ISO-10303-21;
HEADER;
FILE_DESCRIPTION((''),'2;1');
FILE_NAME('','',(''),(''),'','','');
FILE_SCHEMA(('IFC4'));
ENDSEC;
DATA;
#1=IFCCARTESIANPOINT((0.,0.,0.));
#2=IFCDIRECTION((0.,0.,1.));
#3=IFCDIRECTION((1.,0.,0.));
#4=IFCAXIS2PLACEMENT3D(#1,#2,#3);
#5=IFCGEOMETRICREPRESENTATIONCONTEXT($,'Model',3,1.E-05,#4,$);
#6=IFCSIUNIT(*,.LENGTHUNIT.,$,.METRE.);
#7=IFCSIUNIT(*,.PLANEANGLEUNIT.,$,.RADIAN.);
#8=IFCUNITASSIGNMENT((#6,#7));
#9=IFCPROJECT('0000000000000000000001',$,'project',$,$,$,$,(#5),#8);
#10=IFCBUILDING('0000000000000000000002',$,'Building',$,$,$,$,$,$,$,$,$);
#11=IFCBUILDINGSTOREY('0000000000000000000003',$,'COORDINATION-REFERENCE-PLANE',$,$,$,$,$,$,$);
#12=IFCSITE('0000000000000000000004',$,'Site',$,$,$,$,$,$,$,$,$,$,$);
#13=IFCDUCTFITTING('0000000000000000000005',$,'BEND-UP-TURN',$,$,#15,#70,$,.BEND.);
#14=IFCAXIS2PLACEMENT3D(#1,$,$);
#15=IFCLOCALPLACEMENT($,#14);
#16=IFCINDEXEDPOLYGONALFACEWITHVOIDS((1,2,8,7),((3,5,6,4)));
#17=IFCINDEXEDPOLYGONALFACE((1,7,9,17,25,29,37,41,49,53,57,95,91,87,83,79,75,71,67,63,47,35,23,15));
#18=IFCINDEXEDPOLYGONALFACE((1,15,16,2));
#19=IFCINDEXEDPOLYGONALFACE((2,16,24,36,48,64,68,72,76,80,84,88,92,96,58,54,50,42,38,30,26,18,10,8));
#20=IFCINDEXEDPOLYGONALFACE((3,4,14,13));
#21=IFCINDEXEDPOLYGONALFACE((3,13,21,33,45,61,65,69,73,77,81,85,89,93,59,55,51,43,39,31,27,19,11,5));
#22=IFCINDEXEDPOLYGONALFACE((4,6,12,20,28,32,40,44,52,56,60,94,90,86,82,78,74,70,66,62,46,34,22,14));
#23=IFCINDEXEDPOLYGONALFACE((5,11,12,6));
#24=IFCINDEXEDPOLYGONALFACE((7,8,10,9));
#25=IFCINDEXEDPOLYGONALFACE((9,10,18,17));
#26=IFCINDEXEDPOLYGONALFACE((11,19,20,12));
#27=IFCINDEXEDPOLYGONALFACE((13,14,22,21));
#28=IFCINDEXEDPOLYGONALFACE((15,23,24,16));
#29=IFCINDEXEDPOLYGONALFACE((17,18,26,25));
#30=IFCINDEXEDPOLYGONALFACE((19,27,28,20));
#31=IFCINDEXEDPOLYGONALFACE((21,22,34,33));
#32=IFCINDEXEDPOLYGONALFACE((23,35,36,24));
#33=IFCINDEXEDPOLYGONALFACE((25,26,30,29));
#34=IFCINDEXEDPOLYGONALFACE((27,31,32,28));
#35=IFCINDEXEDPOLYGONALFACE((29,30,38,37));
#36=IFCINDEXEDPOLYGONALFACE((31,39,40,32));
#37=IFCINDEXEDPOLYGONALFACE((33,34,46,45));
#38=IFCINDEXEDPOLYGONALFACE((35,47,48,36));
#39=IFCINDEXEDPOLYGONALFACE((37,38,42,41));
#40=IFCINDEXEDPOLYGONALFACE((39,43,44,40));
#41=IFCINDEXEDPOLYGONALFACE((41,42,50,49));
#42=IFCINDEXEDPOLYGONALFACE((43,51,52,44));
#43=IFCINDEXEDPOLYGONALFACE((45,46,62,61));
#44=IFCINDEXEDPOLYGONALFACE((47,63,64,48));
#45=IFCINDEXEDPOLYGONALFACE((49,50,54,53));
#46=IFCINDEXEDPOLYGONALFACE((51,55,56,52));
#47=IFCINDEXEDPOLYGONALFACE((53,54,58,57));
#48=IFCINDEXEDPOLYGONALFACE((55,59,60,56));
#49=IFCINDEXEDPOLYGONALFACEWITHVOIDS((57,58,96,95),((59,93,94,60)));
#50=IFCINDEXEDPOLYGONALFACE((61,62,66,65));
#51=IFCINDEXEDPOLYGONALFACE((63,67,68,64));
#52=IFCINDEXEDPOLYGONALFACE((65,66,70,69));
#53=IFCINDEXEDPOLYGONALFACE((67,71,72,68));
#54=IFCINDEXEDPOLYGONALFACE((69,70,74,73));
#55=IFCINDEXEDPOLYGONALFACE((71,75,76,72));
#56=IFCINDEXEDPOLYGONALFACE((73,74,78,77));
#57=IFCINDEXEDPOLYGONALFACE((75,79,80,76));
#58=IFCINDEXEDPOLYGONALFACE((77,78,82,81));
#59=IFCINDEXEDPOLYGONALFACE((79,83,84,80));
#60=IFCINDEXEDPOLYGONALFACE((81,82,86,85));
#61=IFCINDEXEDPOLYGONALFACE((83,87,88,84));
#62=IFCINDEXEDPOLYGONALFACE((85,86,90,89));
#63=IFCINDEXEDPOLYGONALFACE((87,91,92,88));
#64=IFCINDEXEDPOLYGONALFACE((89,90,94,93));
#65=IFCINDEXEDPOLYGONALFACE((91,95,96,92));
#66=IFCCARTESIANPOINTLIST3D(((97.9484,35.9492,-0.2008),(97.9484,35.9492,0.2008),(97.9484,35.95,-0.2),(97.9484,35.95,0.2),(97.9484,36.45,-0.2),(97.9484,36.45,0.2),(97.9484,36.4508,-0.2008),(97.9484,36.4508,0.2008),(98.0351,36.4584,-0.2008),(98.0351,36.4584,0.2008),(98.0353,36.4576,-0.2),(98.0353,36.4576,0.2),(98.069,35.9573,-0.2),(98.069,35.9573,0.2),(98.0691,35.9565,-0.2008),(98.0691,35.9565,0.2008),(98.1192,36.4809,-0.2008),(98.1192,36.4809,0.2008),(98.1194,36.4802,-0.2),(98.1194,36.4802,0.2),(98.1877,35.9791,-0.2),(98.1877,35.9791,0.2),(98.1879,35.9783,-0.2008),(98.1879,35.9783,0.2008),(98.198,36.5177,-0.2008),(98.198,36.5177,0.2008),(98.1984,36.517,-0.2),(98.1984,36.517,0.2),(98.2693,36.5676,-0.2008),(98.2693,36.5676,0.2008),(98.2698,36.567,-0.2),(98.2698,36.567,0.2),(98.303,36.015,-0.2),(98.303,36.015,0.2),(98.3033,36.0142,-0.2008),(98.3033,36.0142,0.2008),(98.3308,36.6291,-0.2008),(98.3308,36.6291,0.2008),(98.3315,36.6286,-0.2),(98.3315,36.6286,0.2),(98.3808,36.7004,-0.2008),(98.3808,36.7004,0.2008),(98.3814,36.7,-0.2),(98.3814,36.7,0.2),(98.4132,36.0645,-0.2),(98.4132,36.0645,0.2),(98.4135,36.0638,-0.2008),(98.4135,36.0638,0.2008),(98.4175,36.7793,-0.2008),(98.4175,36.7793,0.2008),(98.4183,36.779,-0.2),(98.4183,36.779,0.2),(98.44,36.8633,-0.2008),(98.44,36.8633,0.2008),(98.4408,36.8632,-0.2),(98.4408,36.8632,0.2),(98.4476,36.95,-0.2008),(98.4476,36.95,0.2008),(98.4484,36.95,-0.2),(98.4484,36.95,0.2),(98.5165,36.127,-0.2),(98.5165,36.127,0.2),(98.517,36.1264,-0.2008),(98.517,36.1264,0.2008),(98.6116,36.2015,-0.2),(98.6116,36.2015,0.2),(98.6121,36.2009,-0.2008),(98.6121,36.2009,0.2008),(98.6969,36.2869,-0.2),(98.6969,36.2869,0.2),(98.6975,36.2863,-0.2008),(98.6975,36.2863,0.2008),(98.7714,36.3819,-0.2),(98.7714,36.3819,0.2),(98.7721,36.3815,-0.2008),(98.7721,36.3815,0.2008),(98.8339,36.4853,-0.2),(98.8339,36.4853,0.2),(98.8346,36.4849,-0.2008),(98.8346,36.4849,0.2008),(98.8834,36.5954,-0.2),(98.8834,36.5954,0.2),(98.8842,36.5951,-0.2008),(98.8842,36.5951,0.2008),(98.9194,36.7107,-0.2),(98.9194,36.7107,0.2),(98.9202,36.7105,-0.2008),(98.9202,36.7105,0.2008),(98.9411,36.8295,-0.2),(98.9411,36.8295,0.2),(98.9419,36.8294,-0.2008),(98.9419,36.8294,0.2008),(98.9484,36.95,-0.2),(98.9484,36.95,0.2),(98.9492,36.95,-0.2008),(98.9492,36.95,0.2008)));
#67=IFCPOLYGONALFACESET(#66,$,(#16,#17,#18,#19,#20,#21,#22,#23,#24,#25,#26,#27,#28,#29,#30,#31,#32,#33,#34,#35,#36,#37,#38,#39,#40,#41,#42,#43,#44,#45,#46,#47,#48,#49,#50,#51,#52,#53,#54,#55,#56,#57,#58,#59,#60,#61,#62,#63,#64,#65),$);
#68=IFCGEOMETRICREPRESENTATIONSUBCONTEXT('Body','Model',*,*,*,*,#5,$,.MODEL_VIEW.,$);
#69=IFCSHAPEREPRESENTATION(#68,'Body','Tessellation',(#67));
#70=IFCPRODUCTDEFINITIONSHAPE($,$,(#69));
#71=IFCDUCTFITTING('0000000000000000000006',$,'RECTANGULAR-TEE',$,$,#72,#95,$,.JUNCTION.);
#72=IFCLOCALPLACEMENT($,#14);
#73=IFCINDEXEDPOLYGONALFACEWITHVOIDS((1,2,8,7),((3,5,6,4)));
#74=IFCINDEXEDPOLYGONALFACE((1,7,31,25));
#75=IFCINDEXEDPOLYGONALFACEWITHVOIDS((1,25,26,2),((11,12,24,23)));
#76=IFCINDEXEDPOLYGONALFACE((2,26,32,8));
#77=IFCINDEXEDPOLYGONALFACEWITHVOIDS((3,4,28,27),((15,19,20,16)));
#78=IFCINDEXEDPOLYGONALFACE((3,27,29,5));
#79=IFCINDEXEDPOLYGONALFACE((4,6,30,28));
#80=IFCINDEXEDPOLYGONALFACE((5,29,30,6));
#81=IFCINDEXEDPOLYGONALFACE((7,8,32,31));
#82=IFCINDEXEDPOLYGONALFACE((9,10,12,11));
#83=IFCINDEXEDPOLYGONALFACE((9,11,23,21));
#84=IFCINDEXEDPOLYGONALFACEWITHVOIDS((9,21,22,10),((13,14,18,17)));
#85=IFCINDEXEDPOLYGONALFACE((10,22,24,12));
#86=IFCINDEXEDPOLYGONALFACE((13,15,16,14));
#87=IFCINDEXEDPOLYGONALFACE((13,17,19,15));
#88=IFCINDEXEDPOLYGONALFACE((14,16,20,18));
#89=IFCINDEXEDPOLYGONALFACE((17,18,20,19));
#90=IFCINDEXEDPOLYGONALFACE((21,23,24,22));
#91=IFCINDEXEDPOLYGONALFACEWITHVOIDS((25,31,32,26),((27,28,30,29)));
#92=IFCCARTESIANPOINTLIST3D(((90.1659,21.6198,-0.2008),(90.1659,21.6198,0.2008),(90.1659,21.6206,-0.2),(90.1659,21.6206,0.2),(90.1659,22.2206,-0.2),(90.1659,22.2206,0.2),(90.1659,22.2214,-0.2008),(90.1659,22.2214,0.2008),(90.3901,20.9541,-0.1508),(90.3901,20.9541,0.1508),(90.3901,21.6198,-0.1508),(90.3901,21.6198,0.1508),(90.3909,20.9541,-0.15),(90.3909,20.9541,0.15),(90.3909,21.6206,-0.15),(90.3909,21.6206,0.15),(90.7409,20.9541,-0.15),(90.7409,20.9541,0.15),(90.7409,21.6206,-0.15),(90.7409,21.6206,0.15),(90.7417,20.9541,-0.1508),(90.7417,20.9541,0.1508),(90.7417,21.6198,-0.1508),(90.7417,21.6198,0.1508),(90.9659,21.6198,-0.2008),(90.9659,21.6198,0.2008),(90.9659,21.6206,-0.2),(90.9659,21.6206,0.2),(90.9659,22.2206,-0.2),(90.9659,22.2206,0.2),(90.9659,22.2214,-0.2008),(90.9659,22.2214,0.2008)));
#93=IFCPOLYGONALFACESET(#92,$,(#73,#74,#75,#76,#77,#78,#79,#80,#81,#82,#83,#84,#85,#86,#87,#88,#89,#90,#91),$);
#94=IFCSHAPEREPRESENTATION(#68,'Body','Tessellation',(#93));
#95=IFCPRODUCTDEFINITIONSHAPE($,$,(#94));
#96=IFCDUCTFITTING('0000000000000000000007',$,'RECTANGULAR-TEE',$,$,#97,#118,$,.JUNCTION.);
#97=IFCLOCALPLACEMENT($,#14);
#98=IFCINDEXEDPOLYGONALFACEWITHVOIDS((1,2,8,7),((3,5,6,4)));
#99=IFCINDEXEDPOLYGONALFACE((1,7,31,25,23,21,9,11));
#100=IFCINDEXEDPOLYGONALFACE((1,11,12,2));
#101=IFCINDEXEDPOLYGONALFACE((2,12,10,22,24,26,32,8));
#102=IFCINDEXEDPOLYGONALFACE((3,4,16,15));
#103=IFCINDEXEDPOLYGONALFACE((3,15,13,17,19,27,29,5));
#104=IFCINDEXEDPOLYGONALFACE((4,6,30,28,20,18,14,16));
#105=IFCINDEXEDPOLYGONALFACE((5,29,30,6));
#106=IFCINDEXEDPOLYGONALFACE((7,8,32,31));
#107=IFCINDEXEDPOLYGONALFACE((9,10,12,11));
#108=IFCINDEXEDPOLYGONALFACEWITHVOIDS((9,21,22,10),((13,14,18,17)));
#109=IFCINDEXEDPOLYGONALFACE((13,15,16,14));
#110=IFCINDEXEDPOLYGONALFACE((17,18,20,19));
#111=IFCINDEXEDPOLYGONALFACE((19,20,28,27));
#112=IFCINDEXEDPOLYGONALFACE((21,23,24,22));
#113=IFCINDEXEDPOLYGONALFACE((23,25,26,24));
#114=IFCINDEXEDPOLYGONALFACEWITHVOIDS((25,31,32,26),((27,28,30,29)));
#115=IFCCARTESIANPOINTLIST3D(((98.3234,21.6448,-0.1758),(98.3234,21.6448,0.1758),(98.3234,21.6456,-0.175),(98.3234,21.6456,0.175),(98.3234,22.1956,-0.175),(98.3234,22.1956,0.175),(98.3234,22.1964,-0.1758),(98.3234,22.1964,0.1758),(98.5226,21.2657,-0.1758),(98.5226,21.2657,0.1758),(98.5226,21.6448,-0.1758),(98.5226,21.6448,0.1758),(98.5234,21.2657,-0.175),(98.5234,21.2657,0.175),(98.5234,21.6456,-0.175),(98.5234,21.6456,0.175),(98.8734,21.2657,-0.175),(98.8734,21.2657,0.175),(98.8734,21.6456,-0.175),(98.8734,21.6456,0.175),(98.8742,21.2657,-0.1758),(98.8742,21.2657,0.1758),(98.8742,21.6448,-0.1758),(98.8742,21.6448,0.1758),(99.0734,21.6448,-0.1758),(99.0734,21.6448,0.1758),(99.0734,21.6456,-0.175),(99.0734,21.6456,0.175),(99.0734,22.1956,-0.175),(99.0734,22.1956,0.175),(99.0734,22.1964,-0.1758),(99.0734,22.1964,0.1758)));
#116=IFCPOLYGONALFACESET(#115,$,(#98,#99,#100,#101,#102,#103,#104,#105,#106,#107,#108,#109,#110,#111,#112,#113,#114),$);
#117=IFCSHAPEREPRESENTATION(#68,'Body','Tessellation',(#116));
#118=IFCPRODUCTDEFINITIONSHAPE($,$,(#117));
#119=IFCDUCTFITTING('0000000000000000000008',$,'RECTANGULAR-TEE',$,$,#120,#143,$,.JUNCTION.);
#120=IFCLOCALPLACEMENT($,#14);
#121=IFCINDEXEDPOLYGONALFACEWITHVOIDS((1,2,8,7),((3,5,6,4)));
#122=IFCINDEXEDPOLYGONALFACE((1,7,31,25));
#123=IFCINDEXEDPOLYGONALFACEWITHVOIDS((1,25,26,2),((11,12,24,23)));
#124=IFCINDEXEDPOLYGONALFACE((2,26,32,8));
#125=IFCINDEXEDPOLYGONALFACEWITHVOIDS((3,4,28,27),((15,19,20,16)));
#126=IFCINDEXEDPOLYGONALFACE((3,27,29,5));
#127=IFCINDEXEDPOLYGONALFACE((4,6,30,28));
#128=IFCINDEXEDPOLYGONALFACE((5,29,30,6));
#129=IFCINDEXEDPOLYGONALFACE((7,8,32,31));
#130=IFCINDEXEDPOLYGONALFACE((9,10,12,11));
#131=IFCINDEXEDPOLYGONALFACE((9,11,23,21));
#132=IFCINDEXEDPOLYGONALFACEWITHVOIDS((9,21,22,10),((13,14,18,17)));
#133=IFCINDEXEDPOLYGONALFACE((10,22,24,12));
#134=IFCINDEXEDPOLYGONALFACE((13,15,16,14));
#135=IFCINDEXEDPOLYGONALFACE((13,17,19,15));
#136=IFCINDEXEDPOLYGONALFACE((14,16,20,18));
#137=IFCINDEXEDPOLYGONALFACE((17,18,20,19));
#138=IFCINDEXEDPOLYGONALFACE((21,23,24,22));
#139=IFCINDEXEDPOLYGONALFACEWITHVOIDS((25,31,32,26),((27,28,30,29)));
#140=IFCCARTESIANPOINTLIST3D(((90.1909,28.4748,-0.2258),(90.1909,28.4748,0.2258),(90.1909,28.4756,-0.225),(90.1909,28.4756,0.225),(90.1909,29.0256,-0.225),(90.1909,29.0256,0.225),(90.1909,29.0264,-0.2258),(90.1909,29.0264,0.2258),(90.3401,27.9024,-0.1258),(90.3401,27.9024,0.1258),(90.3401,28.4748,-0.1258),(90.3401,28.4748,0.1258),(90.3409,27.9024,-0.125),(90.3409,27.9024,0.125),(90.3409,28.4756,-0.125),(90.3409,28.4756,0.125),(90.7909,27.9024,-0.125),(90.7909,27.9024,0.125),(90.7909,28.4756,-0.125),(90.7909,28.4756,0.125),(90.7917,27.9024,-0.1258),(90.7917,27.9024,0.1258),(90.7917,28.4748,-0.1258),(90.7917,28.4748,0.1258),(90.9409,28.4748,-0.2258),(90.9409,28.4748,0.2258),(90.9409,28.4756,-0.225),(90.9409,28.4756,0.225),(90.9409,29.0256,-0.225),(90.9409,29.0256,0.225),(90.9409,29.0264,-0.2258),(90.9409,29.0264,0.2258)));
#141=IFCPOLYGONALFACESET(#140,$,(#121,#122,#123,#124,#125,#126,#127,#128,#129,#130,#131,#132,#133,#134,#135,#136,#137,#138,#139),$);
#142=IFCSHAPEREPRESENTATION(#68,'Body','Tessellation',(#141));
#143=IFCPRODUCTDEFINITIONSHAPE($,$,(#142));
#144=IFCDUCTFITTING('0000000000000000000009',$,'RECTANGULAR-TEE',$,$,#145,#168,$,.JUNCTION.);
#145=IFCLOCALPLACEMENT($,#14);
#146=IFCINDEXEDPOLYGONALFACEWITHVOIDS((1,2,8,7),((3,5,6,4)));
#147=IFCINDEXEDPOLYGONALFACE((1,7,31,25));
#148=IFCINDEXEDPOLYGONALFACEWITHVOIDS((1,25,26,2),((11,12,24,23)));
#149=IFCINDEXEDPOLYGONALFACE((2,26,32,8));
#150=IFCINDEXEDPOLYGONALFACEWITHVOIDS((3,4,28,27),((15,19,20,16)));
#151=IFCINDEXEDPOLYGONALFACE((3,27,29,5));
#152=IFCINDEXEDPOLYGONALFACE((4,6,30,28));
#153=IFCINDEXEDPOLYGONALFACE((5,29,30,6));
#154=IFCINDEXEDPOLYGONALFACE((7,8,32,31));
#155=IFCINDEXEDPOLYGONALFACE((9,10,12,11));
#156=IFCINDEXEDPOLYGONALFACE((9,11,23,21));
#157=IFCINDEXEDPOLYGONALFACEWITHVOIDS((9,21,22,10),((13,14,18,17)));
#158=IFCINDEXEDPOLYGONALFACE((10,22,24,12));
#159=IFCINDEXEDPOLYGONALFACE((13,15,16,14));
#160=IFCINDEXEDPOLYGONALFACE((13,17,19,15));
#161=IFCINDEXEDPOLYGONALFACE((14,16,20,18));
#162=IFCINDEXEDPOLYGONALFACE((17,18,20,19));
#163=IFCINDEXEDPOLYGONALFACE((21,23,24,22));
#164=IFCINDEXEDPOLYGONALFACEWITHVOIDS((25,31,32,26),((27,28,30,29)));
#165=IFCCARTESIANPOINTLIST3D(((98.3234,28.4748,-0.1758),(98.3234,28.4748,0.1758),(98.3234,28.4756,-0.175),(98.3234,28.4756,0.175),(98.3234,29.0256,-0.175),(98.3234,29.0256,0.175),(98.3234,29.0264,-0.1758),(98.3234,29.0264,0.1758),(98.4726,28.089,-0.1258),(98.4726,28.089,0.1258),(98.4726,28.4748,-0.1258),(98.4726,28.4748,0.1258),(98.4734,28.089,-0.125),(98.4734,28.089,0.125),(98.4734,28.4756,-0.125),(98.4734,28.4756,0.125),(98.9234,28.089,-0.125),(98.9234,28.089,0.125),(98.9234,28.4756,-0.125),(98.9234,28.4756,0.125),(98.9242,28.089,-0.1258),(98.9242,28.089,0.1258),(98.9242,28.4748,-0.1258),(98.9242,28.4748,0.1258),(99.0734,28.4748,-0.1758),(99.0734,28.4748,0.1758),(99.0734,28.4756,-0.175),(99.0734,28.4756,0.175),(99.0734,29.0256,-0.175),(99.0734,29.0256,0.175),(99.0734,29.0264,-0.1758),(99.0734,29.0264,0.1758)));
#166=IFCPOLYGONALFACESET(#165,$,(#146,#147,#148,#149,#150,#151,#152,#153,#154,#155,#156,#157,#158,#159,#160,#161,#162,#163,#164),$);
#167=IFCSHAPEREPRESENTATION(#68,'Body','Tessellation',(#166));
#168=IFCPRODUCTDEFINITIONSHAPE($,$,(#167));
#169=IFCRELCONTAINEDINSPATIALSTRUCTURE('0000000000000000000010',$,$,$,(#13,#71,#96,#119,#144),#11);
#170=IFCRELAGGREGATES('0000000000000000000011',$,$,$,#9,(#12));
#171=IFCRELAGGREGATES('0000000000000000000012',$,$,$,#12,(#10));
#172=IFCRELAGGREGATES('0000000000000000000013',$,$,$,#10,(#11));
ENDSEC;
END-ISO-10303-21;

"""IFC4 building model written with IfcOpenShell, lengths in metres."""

from ifc_helpers import new_model, entity, si_unit, frame, origin_with_axes, place, context, subcontext, project, spatial, rectangle, extrude, boolean, element, save


model = new_model("IFC4")

# Units and contexts
model_context = context("Model", 3, precision=1e-05, world=origin_with_axes())
body_context = subcontext(model_context, "Body", "Model", "MODEL_VIEW")
ifc_project = project(units=[si_unit("LENGTHUNIT", "METRE"), si_unit("PLANEANGLEUNIT", "RADIAN")], contexts=[model_context])

# Site, building, storey
site = spatial("IfcSite", under=ifc_project, Name="Site")
building = spatial("IfcBuilding", under=site, Name="Building")
storey = spatial("IfcBuildingStorey", under=building, Name="COORDINATION-REFERENCE-PLANE")

# Duct fittings
duct_fitting_1_placement = place(None, frame((97.9484, 36.95, 0.0), z_axis=(0.0, 0.0, 1.0), x_axis=(0.0, -1.0, 0.0)))
cartesian_point_1 = entity("IfcCartesianPoint", [0.0, 0.0, 0.0])
element("IfcDuctFitting", 1, at=duct_fitting_1_placement, inside=storey, Name="BEND-UP-TURN", PredefinedType="BEND", context=body_context, shape_type="SweptSolid", body=[
    entity("IfcRevolvedAreaSolid", entity("IfcRectangleHollowProfileDef", "AREA", None, entity("IfcAxis2Placement2D", entity("IfcCartesianPoint", [0.75, 0.0])), 0.5016, 0.4016, 0.0008), entity("IfcAxis2Placement3D", cartesian_point_1, entity("IfcDirection", [0.0, -1.0, 0.0]), entity("IfcDirection", [1.0, 0.0, 0.0])), entity("IfcAxis1Placement", cartesian_point_1, entity("IfcDirection", [0.0, 1.0, 0.0])), 1.570796),
])
duct_fitting_2_placement = place(None, frame((90.5659, 21.9206, 0.0), z_axis=(1.0, 0.0, 0.0), x_axis=(0.0, -1.0, 0.0)))
solid_1 = boolean("UNION", extrude(rectangle(XDim=0.6, YDim=0.4), frame((0.0, 0.0, -0.4), z_axis=(0.0, 0.0, 1.0), x_axis=(1.0, 0.0, 0.0)), (0.0, 0.0, 1.0), 0.8), extrude(rectangle(XDim=0.35, YDim=0.3), frame((0.0, 0.0, 0.0), z_axis=(1.0, 0.0, 0.0), x_axis=(0.0, 0.0, -1.0)), (0.0, 0.0, 1.0), 0.9665))
element("IfcDuctFitting", 2, at=duct_fitting_2_placement, inside=storey, Name="RECTANGULAR-TEE", PredefinedType="JUNCTION", context=body_context, shape_type="CSG", body=[
    boolean("DIFFERENCE", boolean("UNION", extrude(rectangle(XDim=0.6016, YDim=0.4016), frame((0.0, 0.0, -0.4), z_axis=(0.0, 0.0, 1.0), x_axis=(1.0, 0.0, 0.0)), (0.0, 0.0, 1.0), 0.8), extrude(rectangle(XDim=0.3516, YDim=0.3016), frame((0.0, 0.0, 0.0), z_axis=(1.0, 0.0, 0.0), x_axis=(0.0, 0.0, -1.0)), (0.0, 0.0, 1.0), 0.9665)), solid_1),
])
duct_fitting_3_placement = place(None, frame((98.6984, 21.9206, 0.0), z_axis=(1.0, 0.0, 0.0), x_axis=(0.0, -1.0, 0.0)))
solid_2 = boolean("UNION", extrude(rectangle(XDim=0.55, YDim=0.35), frame((0.0, 0.0, -0.375), z_axis=(0.0, 0.0, 1.0), x_axis=(1.0, 0.0, 0.0)), (0.0, 0.0, 1.0), 0.75), extrude(rectangle(XDim=0.35, YDim=0.35), frame((0.0, 0.0, 0.0), z_axis=(1.0, 0.0, 0.0), x_axis=(0.0, 0.0, -1.0)), (0.0, 0.0, 1.0), 0.6549))
element("IfcDuctFitting", 3, at=duct_fitting_3_placement, inside=storey, Name="RECTANGULAR-TEE", PredefinedType="JUNCTION", context=body_context, shape_type="CSG", body=[
    boolean("DIFFERENCE", boolean("UNION", extrude(rectangle(XDim=0.5516, YDim=0.3516), frame((0.0, 0.0, -0.375), z_axis=(0.0, 0.0, 1.0), x_axis=(1.0, 0.0, 0.0)), (0.0, 0.0, 1.0), 0.75), extrude(rectangle(XDim=0.3516, YDim=0.3516), frame((0.0, 0.0, 0.0), z_axis=(1.0, 0.0, 0.0), x_axis=(0.0, 0.0, -1.0)), (0.0, 0.0, 1.0), 0.6549)), solid_2),
])
duct_fitting_4_placement = place(None, frame((90.5659, 28.7506, 0.0), z_axis=(1.0, 0.0, 0.0), x_axis=(0.0, -1.0, 0.0)))
solid_3 = boolean("UNION", extrude(rectangle(XDim=0.55, YDim=0.45), frame((0.0, 0.0, -0.375), z_axis=(0.0, 0.0, 1.0), x_axis=(1.0, 0.0, 0.0)), (0.0, 0.0, 1.0), 0.75), extrude(rectangle(XDim=0.45, YDim=0.25), frame((0.0, 0.0, 0.0), z_axis=(1.0, 0.0, 0.0), x_axis=(0.0, 0.0, -1.0)), (0.0, 0.0, 1.0), 0.8482))
element("IfcDuctFitting", 4, at=duct_fitting_4_placement, inside=storey, Name="RECTANGULAR-TEE", PredefinedType="JUNCTION", context=body_context, shape_type="CSG", body=[
    boolean("DIFFERENCE", boolean("UNION", extrude(rectangle(XDim=0.5516, YDim=0.4516), frame((0.0, 0.0, -0.375), z_axis=(0.0, 0.0, 1.0), x_axis=(1.0, 0.0, 0.0)), (0.0, 0.0, 1.0), 0.75), extrude(rectangle(XDim=0.4516, YDim=0.2516), frame((0.0, 0.0, 0.0), z_axis=(1.0, 0.0, 0.0), x_axis=(0.0, 0.0, -1.0)), (0.0, 0.0, 1.0), 0.8482)), solid_3),
])
duct_fitting_5_placement = place(None, frame((98.6984, 28.7506, 0.0), z_axis=(1.0, 0.0, 0.0), x_axis=(0.0, -1.0, 0.0)))
solid_4 = boolean("UNION", extrude(rectangle(XDim=0.55, YDim=0.35), frame((0.0, 0.0, -0.375), z_axis=(0.0, 0.0, 1.0), x_axis=(1.0, 0.0, 0.0)), (0.0, 0.0, 1.0), 0.75), extrude(rectangle(XDim=0.45, YDim=0.25), frame((0.0, 0.0, 0.0), z_axis=(1.0, 0.0, 0.0), x_axis=(0.0, 0.0, -1.0)), (0.0, 0.0, 1.0), 0.6616))
element("IfcDuctFitting", 5, at=duct_fitting_5_placement, inside=storey, Name="RECTANGULAR-TEE", PredefinedType="JUNCTION", context=body_context, shape_type="CSG", body=[
    boolean("DIFFERENCE", boolean("UNION", extrude(rectangle(XDim=0.5516, YDim=0.3516), frame((0.0, 0.0, -0.375), z_axis=(0.0, 0.0, 1.0), x_axis=(1.0, 0.0, 0.0)), (0.0, 0.0, 1.0), 0.75), extrude(rectangle(XDim=0.4516, YDim=0.2516), frame((0.0, 0.0, 0.0), z_axis=(1.0, 0.0, 0.0), x_axis=(0.0, 0.0, -1.0)), (0.0, 0.0, 1.0), 0.6616)), solid_4),
])

save(model, "model.ifc")
